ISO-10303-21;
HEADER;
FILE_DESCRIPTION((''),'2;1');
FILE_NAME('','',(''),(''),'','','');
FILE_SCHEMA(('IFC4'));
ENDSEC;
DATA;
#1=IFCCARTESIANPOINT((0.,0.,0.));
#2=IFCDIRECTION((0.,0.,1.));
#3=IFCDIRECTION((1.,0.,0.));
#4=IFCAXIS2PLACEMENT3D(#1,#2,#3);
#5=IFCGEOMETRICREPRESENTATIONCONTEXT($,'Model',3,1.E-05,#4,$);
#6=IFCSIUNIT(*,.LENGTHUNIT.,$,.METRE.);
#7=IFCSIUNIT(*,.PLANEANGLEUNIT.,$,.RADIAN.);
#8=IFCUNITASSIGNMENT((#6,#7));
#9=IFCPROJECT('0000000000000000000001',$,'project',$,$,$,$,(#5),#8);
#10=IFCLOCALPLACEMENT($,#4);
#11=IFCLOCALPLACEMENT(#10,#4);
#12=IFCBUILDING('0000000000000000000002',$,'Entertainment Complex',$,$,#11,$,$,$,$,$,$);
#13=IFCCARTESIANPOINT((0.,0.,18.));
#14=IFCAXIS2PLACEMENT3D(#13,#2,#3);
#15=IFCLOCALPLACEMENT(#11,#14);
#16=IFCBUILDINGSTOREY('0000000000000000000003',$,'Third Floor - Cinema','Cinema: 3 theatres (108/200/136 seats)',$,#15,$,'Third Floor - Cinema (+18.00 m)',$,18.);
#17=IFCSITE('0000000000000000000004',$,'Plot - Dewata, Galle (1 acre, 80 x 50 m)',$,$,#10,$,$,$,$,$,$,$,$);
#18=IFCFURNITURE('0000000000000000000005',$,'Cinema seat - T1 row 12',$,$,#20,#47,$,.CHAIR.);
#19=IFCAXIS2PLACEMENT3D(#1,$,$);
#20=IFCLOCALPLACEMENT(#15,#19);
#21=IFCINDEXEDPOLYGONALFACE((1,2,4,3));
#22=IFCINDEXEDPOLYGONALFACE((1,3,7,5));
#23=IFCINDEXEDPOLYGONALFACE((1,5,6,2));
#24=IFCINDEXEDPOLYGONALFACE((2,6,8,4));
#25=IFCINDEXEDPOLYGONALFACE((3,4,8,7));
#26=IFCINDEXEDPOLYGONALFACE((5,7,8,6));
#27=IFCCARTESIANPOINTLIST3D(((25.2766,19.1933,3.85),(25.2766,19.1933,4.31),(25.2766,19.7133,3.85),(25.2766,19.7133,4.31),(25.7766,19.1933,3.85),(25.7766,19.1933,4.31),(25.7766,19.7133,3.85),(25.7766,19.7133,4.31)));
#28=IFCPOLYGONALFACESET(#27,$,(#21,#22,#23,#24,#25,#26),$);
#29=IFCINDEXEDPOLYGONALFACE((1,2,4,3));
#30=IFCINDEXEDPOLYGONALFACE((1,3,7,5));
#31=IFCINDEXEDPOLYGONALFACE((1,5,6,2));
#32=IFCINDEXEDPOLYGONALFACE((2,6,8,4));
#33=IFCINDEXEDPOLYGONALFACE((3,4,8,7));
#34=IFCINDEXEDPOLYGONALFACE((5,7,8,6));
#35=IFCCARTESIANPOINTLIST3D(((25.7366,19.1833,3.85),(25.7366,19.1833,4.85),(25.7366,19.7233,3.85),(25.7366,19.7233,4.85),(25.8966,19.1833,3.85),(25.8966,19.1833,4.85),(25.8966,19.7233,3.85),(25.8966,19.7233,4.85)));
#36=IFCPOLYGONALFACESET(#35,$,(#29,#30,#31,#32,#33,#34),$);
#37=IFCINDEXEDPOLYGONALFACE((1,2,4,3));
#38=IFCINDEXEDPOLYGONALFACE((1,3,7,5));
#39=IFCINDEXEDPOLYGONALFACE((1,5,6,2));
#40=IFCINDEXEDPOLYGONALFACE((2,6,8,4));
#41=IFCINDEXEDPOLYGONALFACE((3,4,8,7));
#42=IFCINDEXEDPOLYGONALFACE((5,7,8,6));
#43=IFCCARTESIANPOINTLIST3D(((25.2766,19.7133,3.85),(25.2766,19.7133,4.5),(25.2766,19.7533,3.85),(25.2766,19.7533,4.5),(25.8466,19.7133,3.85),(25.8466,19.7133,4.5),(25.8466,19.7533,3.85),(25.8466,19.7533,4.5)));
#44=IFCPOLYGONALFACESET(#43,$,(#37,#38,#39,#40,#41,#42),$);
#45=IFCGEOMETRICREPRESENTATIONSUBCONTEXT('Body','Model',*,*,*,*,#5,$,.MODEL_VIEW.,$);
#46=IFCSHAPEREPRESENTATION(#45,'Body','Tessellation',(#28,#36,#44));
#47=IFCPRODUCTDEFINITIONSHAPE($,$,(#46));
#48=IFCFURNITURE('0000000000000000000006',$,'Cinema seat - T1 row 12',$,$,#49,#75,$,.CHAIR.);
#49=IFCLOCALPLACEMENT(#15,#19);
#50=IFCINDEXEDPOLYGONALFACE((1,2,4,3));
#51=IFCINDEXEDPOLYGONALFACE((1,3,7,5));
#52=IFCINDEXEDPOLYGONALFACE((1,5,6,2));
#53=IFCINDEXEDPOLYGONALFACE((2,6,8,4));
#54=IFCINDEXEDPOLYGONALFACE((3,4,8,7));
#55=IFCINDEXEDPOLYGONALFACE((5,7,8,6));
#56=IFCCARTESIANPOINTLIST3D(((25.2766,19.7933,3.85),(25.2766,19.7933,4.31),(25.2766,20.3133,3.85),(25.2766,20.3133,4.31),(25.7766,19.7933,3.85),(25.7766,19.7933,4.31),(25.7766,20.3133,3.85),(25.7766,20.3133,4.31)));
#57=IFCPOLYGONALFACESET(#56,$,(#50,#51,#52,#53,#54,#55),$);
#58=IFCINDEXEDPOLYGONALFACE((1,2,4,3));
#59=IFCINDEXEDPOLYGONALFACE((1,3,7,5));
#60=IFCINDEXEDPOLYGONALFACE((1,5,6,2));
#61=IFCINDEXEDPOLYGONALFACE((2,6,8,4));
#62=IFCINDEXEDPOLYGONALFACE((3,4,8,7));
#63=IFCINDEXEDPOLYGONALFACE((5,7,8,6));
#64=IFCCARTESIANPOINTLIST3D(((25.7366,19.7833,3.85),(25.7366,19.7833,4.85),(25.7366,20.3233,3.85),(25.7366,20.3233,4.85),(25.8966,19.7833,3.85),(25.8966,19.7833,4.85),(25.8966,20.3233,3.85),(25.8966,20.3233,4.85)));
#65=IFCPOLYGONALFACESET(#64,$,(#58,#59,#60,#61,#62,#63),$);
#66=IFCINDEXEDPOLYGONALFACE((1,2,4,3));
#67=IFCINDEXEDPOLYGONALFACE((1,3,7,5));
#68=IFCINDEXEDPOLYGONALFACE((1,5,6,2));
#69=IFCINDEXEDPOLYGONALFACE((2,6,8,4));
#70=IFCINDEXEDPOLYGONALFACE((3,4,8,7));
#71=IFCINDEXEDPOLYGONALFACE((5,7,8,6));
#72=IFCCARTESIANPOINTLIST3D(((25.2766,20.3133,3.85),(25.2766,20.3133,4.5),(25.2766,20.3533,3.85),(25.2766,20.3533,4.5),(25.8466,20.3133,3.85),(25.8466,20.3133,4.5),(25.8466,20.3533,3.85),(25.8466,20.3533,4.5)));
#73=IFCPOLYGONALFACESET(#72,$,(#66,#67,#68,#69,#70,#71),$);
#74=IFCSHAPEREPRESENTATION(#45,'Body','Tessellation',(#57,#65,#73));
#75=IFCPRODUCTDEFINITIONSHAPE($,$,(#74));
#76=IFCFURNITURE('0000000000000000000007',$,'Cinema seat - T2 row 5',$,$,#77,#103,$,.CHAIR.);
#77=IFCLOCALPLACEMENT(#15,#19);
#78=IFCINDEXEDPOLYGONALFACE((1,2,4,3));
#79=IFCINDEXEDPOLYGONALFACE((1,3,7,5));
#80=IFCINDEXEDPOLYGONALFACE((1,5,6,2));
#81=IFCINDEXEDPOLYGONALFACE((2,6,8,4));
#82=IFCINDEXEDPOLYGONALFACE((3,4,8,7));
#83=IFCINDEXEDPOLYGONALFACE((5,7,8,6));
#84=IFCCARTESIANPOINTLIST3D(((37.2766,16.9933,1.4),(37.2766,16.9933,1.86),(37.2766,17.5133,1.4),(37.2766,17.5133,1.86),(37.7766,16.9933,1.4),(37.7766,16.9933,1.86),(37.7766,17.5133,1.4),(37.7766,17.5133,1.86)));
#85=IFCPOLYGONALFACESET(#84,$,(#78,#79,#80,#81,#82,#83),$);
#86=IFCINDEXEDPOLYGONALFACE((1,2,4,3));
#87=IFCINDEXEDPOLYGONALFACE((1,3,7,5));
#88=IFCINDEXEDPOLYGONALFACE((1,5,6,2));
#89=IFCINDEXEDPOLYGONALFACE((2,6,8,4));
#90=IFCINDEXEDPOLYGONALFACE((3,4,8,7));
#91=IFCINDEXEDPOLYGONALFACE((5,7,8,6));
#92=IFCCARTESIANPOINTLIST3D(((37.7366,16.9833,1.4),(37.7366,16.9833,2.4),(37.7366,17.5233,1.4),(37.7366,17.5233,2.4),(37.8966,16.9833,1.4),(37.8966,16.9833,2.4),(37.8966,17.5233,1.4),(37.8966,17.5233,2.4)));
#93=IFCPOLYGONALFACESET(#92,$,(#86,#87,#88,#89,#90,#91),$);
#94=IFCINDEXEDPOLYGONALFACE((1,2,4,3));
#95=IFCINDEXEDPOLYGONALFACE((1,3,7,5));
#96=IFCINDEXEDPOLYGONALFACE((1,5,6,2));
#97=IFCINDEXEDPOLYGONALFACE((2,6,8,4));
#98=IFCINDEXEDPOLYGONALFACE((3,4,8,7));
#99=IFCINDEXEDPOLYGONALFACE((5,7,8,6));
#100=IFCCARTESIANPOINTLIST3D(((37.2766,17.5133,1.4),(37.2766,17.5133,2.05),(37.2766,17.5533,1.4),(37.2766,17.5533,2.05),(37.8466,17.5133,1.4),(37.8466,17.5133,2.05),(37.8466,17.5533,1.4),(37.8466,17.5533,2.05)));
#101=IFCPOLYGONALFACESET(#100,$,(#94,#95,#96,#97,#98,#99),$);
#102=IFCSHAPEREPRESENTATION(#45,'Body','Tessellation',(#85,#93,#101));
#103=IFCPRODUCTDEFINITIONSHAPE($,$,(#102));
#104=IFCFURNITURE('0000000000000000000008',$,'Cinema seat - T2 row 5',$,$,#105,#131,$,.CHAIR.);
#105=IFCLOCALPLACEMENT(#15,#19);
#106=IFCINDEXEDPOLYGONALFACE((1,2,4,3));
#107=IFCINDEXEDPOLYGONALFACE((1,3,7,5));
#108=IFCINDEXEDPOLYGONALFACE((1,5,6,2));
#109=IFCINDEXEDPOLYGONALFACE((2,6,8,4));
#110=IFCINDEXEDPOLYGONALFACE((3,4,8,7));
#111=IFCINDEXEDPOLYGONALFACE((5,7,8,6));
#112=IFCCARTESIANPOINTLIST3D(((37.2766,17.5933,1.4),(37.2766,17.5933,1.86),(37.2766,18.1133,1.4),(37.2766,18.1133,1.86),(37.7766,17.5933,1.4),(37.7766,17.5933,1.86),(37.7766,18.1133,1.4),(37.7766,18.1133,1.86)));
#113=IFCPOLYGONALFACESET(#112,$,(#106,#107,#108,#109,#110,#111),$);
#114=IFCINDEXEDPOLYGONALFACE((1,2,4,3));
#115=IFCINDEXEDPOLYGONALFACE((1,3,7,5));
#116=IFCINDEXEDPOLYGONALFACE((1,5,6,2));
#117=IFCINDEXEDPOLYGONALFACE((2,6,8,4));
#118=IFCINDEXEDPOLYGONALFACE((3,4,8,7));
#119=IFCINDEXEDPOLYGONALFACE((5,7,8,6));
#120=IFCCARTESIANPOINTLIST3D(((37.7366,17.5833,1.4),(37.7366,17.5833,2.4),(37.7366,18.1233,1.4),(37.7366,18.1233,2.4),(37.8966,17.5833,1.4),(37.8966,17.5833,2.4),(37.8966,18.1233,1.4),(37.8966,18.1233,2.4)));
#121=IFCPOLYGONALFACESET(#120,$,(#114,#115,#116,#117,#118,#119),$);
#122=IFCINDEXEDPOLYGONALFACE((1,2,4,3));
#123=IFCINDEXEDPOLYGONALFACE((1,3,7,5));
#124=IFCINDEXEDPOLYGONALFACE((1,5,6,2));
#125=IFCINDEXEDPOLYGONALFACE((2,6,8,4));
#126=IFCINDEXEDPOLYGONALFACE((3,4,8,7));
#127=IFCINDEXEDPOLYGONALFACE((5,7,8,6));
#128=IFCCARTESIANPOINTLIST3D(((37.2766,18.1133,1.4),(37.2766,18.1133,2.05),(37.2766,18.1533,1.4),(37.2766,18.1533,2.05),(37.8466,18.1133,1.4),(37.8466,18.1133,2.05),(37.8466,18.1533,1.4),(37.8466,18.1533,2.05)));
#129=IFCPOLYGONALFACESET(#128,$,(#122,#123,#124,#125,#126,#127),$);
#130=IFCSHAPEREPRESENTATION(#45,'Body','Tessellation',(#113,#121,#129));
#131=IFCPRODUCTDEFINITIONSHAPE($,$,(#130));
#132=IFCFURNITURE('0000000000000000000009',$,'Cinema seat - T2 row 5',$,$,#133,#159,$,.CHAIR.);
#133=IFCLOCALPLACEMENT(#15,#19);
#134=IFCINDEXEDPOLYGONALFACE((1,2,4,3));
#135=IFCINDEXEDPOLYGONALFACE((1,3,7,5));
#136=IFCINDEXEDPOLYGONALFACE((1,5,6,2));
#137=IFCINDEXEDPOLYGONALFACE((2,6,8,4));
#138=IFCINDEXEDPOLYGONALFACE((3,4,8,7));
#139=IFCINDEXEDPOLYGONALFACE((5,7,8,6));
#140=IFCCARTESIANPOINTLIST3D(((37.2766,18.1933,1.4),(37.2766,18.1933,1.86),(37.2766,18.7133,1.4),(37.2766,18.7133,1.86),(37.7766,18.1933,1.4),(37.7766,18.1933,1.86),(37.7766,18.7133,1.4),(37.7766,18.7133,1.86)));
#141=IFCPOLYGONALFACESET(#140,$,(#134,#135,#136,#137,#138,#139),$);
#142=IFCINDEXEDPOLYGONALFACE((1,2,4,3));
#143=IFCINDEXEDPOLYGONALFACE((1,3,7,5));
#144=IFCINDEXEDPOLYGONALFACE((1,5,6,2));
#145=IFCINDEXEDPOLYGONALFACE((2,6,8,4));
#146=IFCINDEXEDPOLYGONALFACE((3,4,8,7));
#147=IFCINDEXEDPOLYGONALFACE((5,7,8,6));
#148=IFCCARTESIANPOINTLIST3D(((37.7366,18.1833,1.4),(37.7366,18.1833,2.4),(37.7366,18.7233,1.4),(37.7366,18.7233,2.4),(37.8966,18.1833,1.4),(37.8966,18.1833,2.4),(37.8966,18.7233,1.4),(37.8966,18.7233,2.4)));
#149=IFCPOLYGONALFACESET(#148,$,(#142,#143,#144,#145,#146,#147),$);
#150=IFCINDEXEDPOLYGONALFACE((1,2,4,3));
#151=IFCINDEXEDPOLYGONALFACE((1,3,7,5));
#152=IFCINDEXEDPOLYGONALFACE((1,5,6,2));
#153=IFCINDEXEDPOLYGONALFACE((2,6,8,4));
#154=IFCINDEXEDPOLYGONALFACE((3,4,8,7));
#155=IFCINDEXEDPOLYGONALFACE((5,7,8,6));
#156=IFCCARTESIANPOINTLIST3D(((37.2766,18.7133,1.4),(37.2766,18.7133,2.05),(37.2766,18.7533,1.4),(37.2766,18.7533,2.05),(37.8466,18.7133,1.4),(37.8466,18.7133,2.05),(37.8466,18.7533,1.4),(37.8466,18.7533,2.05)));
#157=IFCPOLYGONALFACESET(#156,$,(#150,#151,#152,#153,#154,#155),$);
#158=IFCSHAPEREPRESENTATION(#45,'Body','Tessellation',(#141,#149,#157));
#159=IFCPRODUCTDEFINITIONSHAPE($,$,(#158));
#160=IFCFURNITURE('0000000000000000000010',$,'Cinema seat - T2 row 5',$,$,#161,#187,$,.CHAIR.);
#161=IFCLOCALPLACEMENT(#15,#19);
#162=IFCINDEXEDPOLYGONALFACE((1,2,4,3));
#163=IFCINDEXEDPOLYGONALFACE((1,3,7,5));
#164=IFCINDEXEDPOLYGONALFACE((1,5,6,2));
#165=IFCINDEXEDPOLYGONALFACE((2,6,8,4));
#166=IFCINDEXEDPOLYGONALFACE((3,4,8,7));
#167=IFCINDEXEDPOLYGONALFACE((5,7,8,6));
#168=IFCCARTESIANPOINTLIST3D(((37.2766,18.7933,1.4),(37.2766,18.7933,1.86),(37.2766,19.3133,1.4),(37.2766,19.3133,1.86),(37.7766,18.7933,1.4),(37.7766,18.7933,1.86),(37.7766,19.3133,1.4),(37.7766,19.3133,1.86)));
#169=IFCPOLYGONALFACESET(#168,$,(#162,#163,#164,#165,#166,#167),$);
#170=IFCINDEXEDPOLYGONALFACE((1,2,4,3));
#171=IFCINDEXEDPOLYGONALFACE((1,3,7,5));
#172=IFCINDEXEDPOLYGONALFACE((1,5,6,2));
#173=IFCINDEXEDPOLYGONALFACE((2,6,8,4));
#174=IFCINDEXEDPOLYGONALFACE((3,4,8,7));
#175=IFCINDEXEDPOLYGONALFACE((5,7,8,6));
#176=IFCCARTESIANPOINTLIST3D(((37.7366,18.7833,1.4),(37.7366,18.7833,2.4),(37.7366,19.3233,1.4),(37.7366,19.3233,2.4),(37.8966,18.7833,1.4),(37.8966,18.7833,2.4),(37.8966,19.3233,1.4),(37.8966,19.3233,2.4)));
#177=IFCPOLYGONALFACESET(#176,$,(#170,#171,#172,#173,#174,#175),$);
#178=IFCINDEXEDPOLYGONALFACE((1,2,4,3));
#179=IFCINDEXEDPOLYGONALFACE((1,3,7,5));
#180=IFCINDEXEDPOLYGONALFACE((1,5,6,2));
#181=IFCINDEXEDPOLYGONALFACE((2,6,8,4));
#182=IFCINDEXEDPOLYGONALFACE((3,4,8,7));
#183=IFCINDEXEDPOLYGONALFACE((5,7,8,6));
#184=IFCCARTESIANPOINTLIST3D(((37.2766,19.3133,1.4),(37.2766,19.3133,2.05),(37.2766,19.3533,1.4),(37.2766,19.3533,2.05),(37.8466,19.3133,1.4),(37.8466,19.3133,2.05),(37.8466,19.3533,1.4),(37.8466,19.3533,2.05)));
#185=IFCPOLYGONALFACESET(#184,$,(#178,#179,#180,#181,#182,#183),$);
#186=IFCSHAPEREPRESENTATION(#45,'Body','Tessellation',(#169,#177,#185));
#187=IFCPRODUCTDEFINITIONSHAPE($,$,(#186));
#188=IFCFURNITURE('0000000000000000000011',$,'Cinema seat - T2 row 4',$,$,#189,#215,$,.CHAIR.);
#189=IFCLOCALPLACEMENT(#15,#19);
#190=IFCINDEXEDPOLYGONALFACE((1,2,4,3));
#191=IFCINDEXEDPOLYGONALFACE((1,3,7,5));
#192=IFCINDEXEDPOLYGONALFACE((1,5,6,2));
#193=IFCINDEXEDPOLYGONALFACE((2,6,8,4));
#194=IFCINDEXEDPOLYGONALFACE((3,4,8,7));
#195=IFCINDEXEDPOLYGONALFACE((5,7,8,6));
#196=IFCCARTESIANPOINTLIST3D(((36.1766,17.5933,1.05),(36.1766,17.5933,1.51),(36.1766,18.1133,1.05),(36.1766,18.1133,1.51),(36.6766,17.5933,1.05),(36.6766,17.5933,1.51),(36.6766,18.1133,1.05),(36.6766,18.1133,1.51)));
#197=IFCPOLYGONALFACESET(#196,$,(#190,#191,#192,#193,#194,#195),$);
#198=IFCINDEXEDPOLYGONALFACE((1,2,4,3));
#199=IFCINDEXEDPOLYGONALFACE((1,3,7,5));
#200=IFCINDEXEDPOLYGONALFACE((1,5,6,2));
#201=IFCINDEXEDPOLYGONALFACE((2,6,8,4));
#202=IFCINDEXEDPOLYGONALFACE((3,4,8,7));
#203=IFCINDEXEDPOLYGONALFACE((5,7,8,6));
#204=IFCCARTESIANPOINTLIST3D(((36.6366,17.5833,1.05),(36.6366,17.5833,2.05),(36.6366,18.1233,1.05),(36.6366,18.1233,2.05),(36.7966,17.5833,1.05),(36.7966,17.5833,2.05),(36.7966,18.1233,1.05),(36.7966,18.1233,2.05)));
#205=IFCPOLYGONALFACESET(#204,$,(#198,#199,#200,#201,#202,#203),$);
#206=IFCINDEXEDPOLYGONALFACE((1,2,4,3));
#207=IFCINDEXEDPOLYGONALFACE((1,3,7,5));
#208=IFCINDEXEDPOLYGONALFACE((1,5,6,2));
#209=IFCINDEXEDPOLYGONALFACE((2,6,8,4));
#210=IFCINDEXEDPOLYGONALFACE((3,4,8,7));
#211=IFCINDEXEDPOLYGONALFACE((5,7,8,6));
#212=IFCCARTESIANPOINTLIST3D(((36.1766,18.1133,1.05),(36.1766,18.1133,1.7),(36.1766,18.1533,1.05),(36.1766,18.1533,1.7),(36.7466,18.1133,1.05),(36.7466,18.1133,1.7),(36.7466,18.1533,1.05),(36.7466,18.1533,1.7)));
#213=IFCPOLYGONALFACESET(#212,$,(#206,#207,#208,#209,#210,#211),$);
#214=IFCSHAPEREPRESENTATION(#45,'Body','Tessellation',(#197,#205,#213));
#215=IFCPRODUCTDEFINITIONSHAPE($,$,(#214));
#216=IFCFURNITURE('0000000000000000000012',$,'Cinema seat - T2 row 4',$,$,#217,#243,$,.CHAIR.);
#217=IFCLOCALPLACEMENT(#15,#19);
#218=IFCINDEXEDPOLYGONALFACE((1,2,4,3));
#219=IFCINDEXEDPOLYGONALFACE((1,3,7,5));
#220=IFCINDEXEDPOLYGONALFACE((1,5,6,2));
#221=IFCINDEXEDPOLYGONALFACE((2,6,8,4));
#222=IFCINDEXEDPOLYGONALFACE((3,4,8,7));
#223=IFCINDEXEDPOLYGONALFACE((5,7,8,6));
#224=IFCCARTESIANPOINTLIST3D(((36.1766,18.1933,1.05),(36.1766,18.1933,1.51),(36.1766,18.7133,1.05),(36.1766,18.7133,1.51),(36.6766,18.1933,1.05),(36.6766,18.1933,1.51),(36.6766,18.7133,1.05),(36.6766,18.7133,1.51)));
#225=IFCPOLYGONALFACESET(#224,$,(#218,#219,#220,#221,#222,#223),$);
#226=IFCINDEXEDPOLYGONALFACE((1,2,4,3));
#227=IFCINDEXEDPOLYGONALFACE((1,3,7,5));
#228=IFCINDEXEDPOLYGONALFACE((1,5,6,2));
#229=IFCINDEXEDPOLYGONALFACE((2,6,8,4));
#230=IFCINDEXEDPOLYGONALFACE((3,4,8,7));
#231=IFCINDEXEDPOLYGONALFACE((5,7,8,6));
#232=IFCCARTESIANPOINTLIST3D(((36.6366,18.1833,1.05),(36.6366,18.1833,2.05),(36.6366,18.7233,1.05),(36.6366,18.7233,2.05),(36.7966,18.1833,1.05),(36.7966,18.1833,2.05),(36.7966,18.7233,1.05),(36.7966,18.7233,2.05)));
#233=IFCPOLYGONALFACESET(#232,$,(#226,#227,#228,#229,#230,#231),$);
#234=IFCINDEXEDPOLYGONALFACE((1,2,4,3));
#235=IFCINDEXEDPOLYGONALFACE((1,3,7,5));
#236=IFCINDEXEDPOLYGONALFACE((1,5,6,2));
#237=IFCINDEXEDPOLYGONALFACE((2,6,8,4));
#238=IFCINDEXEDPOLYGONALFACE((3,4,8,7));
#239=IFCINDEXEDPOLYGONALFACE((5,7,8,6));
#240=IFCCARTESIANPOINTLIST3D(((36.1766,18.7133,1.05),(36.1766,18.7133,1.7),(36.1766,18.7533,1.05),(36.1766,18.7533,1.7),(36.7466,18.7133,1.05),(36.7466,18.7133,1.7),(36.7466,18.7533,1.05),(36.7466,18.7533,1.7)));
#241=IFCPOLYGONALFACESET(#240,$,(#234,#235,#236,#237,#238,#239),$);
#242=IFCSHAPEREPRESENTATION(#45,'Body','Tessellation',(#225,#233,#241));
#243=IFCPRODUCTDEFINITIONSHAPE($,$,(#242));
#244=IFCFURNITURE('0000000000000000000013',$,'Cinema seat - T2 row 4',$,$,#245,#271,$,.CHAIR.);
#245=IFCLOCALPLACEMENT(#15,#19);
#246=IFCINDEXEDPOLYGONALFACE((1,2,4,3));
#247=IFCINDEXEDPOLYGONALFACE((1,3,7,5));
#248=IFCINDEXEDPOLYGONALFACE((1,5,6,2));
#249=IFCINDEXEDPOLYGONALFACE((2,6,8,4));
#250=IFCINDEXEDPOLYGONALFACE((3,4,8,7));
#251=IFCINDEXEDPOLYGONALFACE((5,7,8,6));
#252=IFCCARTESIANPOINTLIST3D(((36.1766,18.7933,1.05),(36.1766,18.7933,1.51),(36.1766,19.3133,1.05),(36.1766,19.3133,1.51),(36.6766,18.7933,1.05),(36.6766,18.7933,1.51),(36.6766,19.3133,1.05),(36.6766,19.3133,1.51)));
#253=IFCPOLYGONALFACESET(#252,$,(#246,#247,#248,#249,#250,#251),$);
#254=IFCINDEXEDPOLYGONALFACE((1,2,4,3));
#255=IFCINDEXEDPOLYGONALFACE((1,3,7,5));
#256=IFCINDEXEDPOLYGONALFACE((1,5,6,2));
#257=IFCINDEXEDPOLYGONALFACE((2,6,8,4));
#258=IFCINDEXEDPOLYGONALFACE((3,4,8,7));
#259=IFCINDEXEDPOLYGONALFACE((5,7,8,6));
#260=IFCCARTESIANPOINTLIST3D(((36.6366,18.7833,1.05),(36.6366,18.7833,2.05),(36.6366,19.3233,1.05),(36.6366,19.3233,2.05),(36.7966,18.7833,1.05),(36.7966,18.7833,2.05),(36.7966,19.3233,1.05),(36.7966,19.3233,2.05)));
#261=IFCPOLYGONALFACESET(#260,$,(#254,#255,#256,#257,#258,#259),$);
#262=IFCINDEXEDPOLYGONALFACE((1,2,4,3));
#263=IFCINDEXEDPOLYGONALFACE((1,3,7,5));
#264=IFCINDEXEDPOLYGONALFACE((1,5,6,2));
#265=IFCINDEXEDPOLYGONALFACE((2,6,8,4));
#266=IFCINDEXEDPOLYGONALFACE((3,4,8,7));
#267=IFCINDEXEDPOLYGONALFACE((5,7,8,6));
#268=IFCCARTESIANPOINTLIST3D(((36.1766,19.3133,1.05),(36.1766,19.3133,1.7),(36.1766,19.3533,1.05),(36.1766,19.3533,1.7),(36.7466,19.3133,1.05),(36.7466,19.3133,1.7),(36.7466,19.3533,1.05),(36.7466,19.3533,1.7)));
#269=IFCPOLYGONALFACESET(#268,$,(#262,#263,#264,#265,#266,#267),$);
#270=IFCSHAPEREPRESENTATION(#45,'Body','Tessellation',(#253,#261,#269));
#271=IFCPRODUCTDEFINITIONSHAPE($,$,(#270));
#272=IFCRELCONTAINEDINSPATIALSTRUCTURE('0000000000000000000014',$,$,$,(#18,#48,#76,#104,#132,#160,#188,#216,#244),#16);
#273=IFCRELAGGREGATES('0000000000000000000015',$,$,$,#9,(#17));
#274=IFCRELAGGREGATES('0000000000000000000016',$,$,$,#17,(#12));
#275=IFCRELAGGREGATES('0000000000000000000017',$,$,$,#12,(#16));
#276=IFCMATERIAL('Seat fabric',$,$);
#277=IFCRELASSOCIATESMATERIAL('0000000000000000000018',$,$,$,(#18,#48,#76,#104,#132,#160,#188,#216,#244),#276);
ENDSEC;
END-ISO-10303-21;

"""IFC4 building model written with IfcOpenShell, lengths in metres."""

from ifc_helpers import new_model, si_unit, frame, origin_with_axes, place, context, subcontext, project, spatial, polyline, outline, extrude, material, element, save


model = new_model("IFC4")

# Units and contexts
model_context = context("Model", 3, precision=1e-05, world=origin_with_axes())
body_context = subcontext(model_context, "Body", "Model", "MODEL_VIEW")
ifc_project = project(units=[si_unit("LENGTHUNIT", "METRE"), si_unit("PLANEANGLEUNIT", "RADIAN")], contexts=[model_context])

# Site, building, storey
site_placement = place(None, origin_with_axes())
site = spatial("IfcSite", under=ifc_project, at=site_placement, Name="Plot - Dewata, Galle (1 acre, 80 x 50 m)")
building_placement = place(site_placement, origin_with_axes())
building = spatial("IfcBuilding", under=site, at=building_placement, Name="Entertainment Complex")
storey_placement = place(building_placement, frame((0.0, 0.0, 18.0), z_axis=(0.0, 0.0, 1.0), x_axis=(1.0, 0.0, 0.0)))
storey = spatial("IfcBuildingStorey", under=building, at=storey_placement, Name="Third Floor - Cinema", Description="Cinema: 3 theatres (108/200/136 seats)", LongName="Third Floor - Cinema (+18.00 m)", Elevation=18.0)

# Furniture
ifc_material_1 = material(Name="Seat fabric")
for number, where, z_axis, x_axis, name in (
    (1, (25.8966, 19.4533, 3.85), (0.0, 0.0, 1.0), (1.0, 0.0, 0.0), "Cinema seat - T1 row 12"),
    (2, (25.8966, 20.0533, 3.85), (0.0, 0.0, 1.0), (1.0, 0.0, 0.0), "Cinema seat - T1 row 12"),
    (3, (37.8966, 17.2533, 1.4), (0.0, 0.0, 1.0), (1.0, 0.0, 0.0), "Cinema seat - T2 row 5"),
    (4, (37.8966, 17.8533, 1.4), (0.0, 0.0, 1.0), (1.0, 0.0, 0.0), "Cinema seat - T2 row 5"),
    (5, (37.8966, 18.4533, 1.4), (0.0, 0.0, 1.0), (1.0, 0.0, 0.0), "Cinema seat - T2 row 5"),
    (6, (37.8966, 19.0533, 1.4), (0.0, 0.0, 1.0), (1.0, 0.0, 0.0), "Cinema seat - T2 row 5"),
    (7, (36.7966, 17.8533, 1.05), (0.0, 0.0, 1.0), (1.0, 0.0, 0.0), "Cinema seat - T2 row 4"),
    (8, (36.7966, 18.4533, 1.05), (0.0, 0.0, 1.0), (1.0, 0.0, 0.0), "Cinema seat - T2 row 4"),
    (9, (36.7966, 19.0533, 1.05), (0.0, 0.0, 1.0), (1.0, 0.0, 0.0), "Cinema seat - T2 row 4"),
):
    element("IfcFurniture", number, at=place(storey_placement, frame(where, z_axis=z_axis, x_axis=x_axis)), inside=storey, material=ifc_material_1, Name=name, PredefinedType="CHAIR", context=body_context, shape_type="SweptSolid", body=[
        extrude(outline(polyline([(-0.62, -0.26), (-0.12, -0.26), (-0.12, 0.26), (-0.62, 0.26), (-0.62, -0.26)])), origin_with_axes(), (0.0, 0.0, 1.0), 0.46),
        extrude(outline(polyline([(-0.16, -0.27), (0.0, -0.27), (0.0, 0.27), (-0.16, 0.27), (-0.16, -0.27)])), origin_with_axes(), (0.0, 0.0, 1.0), 1.0),
        extrude(outline(polyline([(-0.62, 0.26), (-0.05, 0.26), (-0.05, 0.3), (-0.62, 0.3), (-0.62, 0.26)])), origin_with_axes(), (0.0, 0.0, 1.0), 0.65),
    ])

save(model, "model.ifc")
